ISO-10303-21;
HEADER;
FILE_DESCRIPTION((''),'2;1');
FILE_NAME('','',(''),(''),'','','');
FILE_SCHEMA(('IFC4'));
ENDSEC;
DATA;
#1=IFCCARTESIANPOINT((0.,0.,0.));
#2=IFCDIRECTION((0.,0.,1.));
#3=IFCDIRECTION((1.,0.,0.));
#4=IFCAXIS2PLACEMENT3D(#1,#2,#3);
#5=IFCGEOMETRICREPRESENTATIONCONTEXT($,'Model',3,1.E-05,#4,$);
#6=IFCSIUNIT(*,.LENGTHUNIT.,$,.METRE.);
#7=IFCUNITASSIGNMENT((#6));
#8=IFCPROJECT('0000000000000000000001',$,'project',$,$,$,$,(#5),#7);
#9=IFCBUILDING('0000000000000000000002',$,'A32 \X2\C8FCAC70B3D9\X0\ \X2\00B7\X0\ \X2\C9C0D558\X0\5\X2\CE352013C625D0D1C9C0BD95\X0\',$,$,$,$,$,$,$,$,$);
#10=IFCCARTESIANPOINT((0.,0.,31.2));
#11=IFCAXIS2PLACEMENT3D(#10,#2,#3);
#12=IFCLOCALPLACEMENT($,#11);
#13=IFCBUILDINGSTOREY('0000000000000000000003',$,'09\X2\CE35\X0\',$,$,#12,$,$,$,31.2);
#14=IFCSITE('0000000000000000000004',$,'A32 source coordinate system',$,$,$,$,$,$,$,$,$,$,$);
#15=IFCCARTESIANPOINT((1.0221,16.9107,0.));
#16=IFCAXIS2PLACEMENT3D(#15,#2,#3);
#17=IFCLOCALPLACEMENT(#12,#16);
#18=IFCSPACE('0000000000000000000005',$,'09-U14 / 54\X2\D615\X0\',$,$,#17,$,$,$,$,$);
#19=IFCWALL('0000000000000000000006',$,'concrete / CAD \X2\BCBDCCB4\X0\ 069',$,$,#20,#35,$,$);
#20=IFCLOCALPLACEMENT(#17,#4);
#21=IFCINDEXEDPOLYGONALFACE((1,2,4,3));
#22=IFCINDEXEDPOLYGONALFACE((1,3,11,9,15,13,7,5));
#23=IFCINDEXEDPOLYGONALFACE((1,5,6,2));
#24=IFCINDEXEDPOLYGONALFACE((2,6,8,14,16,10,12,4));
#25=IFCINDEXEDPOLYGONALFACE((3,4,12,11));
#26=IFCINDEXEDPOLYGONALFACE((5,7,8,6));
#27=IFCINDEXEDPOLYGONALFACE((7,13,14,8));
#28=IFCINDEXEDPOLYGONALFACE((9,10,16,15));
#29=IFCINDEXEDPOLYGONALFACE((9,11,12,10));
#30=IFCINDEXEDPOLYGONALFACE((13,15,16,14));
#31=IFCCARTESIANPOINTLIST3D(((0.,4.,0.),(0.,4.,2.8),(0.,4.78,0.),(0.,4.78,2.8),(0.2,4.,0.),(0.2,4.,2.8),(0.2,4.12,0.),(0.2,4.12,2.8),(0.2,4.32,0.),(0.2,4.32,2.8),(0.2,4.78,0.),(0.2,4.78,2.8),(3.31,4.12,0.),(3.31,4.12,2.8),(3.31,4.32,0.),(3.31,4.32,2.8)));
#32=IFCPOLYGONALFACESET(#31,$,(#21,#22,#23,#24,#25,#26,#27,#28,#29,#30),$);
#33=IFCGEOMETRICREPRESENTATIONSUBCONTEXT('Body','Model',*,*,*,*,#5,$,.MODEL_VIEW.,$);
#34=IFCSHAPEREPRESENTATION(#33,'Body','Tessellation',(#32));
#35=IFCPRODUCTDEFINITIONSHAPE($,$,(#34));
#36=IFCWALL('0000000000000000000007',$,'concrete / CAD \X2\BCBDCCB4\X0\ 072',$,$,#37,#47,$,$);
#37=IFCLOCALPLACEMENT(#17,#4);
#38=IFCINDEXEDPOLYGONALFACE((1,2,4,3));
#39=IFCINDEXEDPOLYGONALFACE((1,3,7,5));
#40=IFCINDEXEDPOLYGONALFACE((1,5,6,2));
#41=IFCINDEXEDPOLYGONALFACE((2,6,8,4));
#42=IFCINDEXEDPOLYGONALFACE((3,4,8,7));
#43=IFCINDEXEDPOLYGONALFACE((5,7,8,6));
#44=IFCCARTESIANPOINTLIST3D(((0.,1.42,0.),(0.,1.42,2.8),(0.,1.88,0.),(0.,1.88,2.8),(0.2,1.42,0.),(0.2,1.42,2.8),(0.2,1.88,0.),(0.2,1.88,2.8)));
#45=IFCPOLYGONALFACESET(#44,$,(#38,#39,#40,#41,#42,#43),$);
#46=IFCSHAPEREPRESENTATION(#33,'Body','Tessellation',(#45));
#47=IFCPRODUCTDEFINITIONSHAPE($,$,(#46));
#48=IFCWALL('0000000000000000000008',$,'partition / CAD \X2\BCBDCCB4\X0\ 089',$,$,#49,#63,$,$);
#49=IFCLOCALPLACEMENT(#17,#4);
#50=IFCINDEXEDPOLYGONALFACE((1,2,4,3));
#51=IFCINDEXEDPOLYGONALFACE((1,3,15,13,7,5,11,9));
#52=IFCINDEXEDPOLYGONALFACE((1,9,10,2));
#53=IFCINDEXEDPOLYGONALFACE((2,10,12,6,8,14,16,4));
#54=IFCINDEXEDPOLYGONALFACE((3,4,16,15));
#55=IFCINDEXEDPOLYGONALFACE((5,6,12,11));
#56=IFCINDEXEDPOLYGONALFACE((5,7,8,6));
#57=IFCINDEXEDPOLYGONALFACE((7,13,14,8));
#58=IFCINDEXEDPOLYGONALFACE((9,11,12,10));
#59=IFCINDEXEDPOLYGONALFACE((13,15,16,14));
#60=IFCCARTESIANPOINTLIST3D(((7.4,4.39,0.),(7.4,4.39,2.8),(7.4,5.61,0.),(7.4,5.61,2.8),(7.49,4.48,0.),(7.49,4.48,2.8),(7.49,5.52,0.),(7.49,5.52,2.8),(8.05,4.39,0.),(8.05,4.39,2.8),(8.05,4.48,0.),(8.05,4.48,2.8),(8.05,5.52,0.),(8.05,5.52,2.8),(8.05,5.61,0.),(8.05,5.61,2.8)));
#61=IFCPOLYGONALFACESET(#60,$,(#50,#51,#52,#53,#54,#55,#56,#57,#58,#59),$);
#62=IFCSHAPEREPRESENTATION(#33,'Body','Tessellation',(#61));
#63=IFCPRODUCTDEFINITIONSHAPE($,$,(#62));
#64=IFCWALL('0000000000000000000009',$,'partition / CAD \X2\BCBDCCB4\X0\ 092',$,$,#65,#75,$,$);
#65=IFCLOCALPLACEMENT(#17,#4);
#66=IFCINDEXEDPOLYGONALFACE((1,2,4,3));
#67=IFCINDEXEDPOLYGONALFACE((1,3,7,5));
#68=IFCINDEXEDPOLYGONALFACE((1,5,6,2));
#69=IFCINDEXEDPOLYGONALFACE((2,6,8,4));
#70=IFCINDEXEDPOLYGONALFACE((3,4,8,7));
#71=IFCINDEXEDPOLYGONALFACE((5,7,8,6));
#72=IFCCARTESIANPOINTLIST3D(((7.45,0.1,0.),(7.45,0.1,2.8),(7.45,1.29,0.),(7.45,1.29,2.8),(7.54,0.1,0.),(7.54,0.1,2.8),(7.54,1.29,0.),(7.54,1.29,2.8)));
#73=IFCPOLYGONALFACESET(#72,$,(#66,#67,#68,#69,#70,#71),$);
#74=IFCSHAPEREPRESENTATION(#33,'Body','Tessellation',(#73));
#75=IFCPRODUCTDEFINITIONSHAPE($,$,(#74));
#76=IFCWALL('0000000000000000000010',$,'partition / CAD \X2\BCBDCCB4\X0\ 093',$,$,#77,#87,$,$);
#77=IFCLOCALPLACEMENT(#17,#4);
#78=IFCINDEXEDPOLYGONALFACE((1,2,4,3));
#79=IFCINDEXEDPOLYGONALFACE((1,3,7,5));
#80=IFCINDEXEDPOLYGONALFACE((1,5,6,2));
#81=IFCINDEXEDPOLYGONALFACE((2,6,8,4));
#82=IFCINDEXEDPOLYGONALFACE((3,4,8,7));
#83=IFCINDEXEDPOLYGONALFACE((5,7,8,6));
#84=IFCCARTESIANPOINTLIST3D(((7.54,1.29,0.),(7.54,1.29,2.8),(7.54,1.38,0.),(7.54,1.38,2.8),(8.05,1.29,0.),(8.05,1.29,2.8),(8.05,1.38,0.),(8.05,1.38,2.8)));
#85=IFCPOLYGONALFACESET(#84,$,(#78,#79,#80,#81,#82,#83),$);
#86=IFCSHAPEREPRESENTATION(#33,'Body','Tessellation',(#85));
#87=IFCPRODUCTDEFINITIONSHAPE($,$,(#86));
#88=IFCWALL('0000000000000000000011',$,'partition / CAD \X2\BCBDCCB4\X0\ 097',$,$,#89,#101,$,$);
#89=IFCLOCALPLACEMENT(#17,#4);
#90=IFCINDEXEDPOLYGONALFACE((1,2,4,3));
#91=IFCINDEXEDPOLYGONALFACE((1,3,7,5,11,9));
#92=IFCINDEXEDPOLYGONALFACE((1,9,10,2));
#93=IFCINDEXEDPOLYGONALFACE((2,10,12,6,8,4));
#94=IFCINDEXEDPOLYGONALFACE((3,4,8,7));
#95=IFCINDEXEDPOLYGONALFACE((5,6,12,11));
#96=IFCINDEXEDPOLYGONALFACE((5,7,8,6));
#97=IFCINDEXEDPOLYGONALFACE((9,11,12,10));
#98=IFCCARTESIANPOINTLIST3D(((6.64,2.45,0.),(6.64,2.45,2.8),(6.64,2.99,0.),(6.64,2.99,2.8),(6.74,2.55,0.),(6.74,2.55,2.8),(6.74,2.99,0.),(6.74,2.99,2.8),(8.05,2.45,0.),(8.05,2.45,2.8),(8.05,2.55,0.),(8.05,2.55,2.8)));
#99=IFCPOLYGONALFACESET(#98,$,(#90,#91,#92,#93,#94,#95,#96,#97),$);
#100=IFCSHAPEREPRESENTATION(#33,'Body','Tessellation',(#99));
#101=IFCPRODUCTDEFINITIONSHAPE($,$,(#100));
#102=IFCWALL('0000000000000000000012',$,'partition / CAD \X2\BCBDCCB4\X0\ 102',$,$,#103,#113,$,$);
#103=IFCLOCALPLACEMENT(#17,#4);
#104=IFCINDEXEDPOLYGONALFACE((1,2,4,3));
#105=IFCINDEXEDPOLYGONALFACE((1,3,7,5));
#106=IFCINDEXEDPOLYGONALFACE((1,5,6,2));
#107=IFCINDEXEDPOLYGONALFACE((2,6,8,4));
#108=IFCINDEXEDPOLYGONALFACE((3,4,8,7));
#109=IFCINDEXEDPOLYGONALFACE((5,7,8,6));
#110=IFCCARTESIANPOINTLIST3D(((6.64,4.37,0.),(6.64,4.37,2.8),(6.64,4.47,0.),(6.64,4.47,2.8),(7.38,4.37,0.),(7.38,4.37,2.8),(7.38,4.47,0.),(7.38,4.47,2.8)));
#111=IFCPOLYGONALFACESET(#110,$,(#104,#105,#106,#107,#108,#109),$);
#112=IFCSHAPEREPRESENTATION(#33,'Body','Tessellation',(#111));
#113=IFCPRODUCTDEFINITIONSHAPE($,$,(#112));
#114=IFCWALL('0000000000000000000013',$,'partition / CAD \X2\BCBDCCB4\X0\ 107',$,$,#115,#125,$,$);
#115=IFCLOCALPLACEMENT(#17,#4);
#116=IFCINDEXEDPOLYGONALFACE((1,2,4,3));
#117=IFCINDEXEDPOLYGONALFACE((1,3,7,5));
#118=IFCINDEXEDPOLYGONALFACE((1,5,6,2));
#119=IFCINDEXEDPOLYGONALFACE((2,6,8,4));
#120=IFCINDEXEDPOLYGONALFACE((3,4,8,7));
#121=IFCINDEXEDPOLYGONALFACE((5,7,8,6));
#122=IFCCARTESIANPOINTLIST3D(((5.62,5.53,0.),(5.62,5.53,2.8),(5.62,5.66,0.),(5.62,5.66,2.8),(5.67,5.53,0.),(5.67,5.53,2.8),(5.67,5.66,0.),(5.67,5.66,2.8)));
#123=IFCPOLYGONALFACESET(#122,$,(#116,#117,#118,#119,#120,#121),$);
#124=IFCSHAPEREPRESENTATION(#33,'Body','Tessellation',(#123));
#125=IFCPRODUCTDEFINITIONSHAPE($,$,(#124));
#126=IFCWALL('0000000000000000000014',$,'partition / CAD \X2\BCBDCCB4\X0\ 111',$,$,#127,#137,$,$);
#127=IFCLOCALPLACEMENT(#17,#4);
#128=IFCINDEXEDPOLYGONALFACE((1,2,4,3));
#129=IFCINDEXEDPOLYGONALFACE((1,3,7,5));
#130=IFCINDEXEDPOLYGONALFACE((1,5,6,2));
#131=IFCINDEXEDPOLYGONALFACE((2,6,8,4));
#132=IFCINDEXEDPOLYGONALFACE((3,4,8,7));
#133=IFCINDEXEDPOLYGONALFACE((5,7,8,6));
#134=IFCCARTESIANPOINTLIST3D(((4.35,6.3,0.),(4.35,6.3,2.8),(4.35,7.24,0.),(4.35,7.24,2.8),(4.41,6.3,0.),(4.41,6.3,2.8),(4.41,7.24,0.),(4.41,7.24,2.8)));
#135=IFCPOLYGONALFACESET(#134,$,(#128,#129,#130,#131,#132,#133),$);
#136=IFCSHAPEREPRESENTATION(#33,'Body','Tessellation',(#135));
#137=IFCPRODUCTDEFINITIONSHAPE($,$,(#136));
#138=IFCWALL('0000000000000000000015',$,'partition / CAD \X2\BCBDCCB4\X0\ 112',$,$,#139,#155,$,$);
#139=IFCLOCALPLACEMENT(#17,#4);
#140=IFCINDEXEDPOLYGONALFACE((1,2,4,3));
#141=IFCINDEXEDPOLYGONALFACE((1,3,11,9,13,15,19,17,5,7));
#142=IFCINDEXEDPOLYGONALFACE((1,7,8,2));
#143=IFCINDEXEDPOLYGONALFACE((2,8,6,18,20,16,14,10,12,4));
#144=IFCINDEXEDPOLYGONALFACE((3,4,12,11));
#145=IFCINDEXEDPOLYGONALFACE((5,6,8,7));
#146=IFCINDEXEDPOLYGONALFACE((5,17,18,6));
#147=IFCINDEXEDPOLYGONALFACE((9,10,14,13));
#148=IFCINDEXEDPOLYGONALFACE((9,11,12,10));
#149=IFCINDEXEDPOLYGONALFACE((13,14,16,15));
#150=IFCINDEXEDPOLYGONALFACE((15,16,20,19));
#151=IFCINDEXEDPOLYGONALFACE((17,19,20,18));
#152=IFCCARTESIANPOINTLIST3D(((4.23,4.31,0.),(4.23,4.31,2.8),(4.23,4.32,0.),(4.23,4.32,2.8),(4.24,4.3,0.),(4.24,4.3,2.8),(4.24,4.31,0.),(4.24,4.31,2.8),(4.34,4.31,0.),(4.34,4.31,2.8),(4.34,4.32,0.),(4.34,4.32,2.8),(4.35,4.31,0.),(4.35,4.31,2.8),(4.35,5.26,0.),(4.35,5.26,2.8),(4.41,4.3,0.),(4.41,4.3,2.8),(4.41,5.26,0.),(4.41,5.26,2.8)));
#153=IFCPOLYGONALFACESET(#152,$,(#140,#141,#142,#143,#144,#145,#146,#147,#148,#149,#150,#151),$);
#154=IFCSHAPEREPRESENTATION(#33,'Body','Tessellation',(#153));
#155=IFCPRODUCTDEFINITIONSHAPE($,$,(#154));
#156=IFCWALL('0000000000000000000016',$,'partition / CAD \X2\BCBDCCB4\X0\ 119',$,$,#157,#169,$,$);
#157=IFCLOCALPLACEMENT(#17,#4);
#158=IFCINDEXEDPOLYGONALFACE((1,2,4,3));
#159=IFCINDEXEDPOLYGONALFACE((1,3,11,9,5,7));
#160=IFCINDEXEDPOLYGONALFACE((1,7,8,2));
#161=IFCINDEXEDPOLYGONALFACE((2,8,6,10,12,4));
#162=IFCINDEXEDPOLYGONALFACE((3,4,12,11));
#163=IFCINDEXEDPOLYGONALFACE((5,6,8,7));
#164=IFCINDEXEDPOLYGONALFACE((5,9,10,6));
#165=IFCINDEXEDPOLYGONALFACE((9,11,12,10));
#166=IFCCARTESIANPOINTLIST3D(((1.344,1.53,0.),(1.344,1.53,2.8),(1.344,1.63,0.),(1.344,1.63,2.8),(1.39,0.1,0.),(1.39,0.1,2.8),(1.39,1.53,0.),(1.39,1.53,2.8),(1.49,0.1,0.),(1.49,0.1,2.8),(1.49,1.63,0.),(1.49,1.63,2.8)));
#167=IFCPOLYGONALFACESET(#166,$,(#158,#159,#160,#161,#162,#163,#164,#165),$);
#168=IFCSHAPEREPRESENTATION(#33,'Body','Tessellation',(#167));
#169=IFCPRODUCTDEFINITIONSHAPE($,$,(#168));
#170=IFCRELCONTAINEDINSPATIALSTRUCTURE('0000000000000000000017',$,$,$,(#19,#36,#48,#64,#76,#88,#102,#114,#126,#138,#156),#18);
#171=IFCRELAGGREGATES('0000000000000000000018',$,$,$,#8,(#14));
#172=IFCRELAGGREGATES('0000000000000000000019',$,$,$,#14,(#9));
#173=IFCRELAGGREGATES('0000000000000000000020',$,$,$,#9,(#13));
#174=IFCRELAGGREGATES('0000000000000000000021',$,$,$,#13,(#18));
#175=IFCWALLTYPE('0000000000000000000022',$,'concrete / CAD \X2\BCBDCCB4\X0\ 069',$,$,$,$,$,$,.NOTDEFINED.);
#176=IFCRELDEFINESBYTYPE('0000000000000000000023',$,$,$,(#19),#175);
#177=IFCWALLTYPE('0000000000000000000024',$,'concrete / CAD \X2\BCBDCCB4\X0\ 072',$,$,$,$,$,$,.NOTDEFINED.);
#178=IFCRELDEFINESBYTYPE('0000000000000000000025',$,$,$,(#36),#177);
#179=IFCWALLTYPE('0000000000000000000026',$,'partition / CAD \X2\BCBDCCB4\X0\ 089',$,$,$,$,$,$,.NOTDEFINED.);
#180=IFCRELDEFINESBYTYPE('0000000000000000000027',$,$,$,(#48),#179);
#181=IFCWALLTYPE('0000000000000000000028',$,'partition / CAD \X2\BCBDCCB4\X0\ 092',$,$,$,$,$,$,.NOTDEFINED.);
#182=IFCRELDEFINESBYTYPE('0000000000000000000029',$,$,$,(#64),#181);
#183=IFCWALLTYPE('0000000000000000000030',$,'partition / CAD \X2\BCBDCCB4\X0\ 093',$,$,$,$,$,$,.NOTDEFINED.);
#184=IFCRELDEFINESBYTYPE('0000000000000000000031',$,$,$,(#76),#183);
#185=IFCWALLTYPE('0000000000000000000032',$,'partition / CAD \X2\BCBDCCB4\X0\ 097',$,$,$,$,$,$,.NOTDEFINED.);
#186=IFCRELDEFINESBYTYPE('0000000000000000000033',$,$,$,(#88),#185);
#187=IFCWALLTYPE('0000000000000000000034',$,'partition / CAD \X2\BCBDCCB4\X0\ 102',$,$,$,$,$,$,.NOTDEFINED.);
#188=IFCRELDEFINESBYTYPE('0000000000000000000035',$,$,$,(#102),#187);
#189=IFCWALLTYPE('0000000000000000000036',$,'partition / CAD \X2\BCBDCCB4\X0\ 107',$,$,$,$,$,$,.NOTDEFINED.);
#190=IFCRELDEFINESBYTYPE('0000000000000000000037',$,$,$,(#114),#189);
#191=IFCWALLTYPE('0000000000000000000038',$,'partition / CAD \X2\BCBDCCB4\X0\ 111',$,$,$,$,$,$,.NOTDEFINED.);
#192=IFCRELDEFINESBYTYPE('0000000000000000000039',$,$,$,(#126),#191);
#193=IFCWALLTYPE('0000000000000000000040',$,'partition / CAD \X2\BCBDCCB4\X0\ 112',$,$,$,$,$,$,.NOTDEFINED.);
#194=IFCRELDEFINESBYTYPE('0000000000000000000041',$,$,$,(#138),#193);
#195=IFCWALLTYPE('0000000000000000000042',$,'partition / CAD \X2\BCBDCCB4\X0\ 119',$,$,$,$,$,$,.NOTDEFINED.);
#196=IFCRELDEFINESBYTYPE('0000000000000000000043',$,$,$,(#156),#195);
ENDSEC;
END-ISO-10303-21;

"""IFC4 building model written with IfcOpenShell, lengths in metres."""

from ifc_helpers import new_model, si_unit, frame, origin, origin_with_axes, place, context, subcontext, project, spatial, polyline, outline, extrude, source, transform, mapped, type_object, type_shapes, element, save


model = new_model("IFC4")

# Units and contexts
model_context = context("Model", 3, precision=1e-05, world=origin_with_axes())
body_context = subcontext(model_context, "Body", "Model", "MODEL_VIEW")
ifc_project = project(units=[si_unit("LENGTHUNIT", "METRE")], contexts=[model_context])

# Site, building, storey, space
site = spatial("IfcSite", under=ifc_project, Name="A32 source coordinate system")
building = spatial("IfcBuilding", under=site, Name="A32 주거동 · 지하5층–옥탑지붕")
storey_placement = place(None, frame((0.0, 0.0, 31.2), z_axis=(0.0, 0.0, 1.0), x_axis=(1.0, 0.0, 0.0)))
storey = spatial("IfcBuildingStorey", under=building, at=storey_placement, Name="09층", Elevation=31.2)
space_placement = place(storey_placement, frame((1.0221, 16.9107, 0.0), z_axis=(0.0, 0.0, 1.0), x_axis=(1.0, 0.0, 0.0)))
space = spatial("IfcSpace", under=storey, at=space_placement, Name="09-U14 / 54형")

# Walls
wall_type_1 = type_object("IfcWallType", Name="concrete / CAD 벽체 069", PredefinedType="NOTDEFINED")
shared_shape_1 = source(origin(), body_context, "Body", "SweptSolid", [
    extrude(outline(polyline([(0.2, 4.12), (0.2, 4.0), (0.0, 4.0), (0.0, 4.78), (0.2, 4.78), (0.2, 4.32), (3.31, 4.32), (3.31, 4.12), (0.2, 4.12)])), origin(), (0.0, 0.0, 1.0), 2.8),
])
type_shapes(wall_type_1, [shared_shape_1])
wall_1_placement = place(space_placement, origin_with_axes())
element("IfcWall", 1, at=wall_1_placement, inside=space, type_object=wall_type_1, Name="concrete / CAD 벽체 069", context=body_context, shape_type="MappedRepresentation", body=[
    mapped(shared_shape_1, transform((0.0, 0.0, 0.0), scale=1.0)),
])
wall_type_2 = type_object("IfcWallType", Name="concrete / CAD 벽체 072", PredefinedType="NOTDEFINED")
shared_shape_2 = source(origin(), body_context, "Body", "SweptSolid", [
    extrude(outline(polyline([(0.2, 1.88), (0.2, 1.42), (0.0, 1.42), (0.0, 1.88), (0.2, 1.88)])), origin(), (0.0, 0.0, 1.0), 2.8),
])
type_shapes(wall_type_2, [shared_shape_2])
wall_2_placement = place(space_placement, origin_with_axes())
element("IfcWall", 2, at=wall_2_placement, inside=space, type_object=wall_type_2, Name="concrete / CAD 벽체 072", context=body_context, shape_type="MappedRepresentation", body=[
    mapped(shared_shape_2, transform((0.0, 0.0, 0.0), scale=1.0)),
])
wall_type_3 = type_object("IfcWallType", Name="partition / CAD 벽체 089", PredefinedType="NOTDEFINED")
shared_shape_3 = source(origin(), body_context, "Body", "SweptSolid", [
    extrude(outline(polyline([(7.49, 4.48), (8.05, 4.48), (8.05, 4.39), (7.4, 4.39), (7.4, 5.61), (8.05, 5.61), (8.05, 5.52), (7.49, 5.52), (7.49, 4.48)])), origin(), (0.0, 0.0, 1.0), 2.8),
])
type_shapes(wall_type_3, [shared_shape_3])
wall_3_placement = place(space_placement, origin_with_axes())
element("IfcWall", 3, at=wall_3_placement, inside=space, type_object=wall_type_3, Name="partition / CAD 벽체 089", context=body_context, shape_type="MappedRepresentation", body=[
    mapped(shared_shape_3, transform((0.0, 0.0, 0.0), scale=1.0)),
])
wall_type_4 = type_object("IfcWallType", Name="partition / CAD 벽체 092", PredefinedType="NOTDEFINED")
shared_shape_4 = source(origin(), body_context, "Body", "SweptSolid", [
    extrude(outline(polyline([(7.54, 1.29), (7.54, 0.1), (7.45, 0.1), (7.45, 1.29), (7.54, 1.29)])), origin(), (0.0, 0.0, 1.0), 2.8),
])
type_shapes(wall_type_4, [shared_shape_4])
wall_4_placement = place(space_placement, origin_with_axes())
element("IfcWall", 4, at=wall_4_placement, inside=space, type_object=wall_type_4, Name="partition / CAD 벽체 092", context=body_context, shape_type="MappedRepresentation", body=[
    mapped(shared_shape_4, transform((0.0, 0.0, 0.0), scale=1.0)),
])
wall_type_5 = type_object("IfcWallType", Name="partition / CAD 벽체 093", PredefinedType="NOTDEFINED")
shared_shape_5 = source(origin(), body_context, "Body", "SweptSolid", [
    extrude(outline(polyline([(8.05, 1.29), (7.54, 1.29), (7.54, 1.38), (8.05, 1.38), (8.05, 1.29)])), origin(), (0.0, 0.0, 1.0), 2.8),
])
type_shapes(wall_type_5, [shared_shape_5])
wall_5_placement = place(space_placement, origin_with_axes())
element("IfcWall", 5, at=wall_5_placement, inside=space, type_object=wall_type_5, Name="partition / CAD 벽체 093", context=body_context, shape_type="MappedRepresentation", body=[
    mapped(shared_shape_5, transform((0.0, 0.0, 0.0), scale=1.0)),
])
wall_type_6 = type_object("IfcWallType", Name="partition / CAD 벽체 097", PredefinedType="NOTDEFINED")
shared_shape_6 = source(origin(), body_context, "Body", "SweptSolid", [
    extrude(outline(polyline([(8.05, 2.45), (6.64, 2.45), (6.64, 2.99), (6.74, 2.99), (6.74, 2.55), (8.05, 2.55), (8.05, 2.45)])), origin(), (0.0, 0.0, 1.0), 2.8),
])
type_shapes(wall_type_6, [shared_shape_6])
wall_6_placement = place(space_placement, origin_with_axes())
element("IfcWall", 6, at=wall_6_placement, inside=space, type_object=wall_type_6, Name="partition / CAD 벽체 097", context=body_context, shape_type="MappedRepresentation", body=[
    mapped(shared_shape_6, transform((0.0, 0.0, 0.0), scale=1.0)),
])
wall_type_7 = type_object("IfcWallType", Name="partition / CAD 벽체 102", PredefinedType="NOTDEFINED")
shared_shape_7 = source(origin(), body_context, "Body", "SweptSolid", [
    extrude(outline(polyline([(7.38, 4.47), (7.38, 4.37), (6.64, 4.37), (6.64, 4.47), (7.38, 4.47)])), origin(), (0.0, 0.0, 1.0), 2.8),
])
type_shapes(wall_type_7, [shared_shape_7])
wall_7_placement = place(space_placement, origin_with_axes())
element("IfcWall", 7, at=wall_7_placement, inside=space, type_object=wall_type_7, Name="partition / CAD 벽체 102", context=body_context, shape_type="MappedRepresentation", body=[
    mapped(shared_shape_7, transform((0.0, 0.0, 0.0), scale=1.0)),
])
wall_type_8 = type_object("IfcWallType", Name="partition / CAD 벽체 107", PredefinedType="NOTDEFINED")
shared_shape_8 = source(origin(), body_context, "Body", "SweptSolid", [
    extrude(outline(polyline([(5.62, 5.53), (5.62, 5.66), (5.67, 5.66), (5.67, 5.53), (5.62, 5.53)])), origin(), (0.0, 0.0, 1.0), 2.8),
])
type_shapes(wall_type_8, [shared_shape_8])
wall_8_placement = place(space_placement, origin_with_axes())
element("IfcWall", 8, at=wall_8_placement, inside=space, type_object=wall_type_8, Name="partition / CAD 벽체 107", context=body_context, shape_type="MappedRepresentation", body=[
    mapped(shared_shape_8, transform((0.0, 0.0, 0.0), scale=1.0)),
])
wall_type_9 = type_object("IfcWallType", Name="partition / CAD 벽체 111", PredefinedType="NOTDEFINED")
shared_shape_9 = source(origin(), body_context, "Body", "SweptSolid", [
    extrude(outline(polyline([(4.41, 7.24), (4.41, 6.3), (4.35, 6.3), (4.35, 7.24), (4.41, 7.24)])), origin(), (0.0, 0.0, 1.0), 2.8),
])
type_shapes(wall_type_9, [shared_shape_9])
wall_9_placement = place(space_placement, origin_with_axes())
element("IfcWall", 9, at=wall_9_placement, inside=space, type_object=wall_type_9, Name="partition / CAD 벽체 111", context=body_context, shape_type="MappedRepresentation", body=[
    mapped(shared_shape_9, transform((0.0, 0.0, 0.0), scale=1.0)),
])
wall_type_10 = type_object("IfcWallType", Name="partition / CAD 벽체 112", PredefinedType="NOTDEFINED")
shared_shape_10 = source(origin(), body_context, "Body", "SweptSolid", [
    extrude(outline(polyline([(4.24, 4.3), (4.24, 4.31), (4.23, 4.31), (4.23, 4.32), (4.34, 4.32), (4.34, 4.31), (4.35, 4.31), (4.35, 5.26), (4.41, 5.26), (4.41, 4.3), (4.24, 4.3)])), origin(), (0.0, 0.0, 1.0), 2.8),
])
type_shapes(wall_type_10, [shared_shape_10])
wall_10_placement = place(space_placement, origin_with_axes())
element("IfcWall", 10, at=wall_10_placement, inside=space, type_object=wall_type_10, Name="partition / CAD 벽체 112", context=body_context, shape_type="MappedRepresentation", body=[
    mapped(shared_shape_10, transform((0.0, 0.0, 0.0), scale=1.0)),
])
wall_type_11 = type_object("IfcWallType", Name="partition / CAD 벽체 119", PredefinedType="NOTDEFINED")
shared_shape_11 = source(origin(), body_context, "Body", "SweptSolid", [
    extrude(outline(polyline([(1.344, 1.53), (1.344, 1.63), (1.49, 1.63), (1.49, 0.1), (1.39, 0.1), (1.39, 1.53), (1.344, 1.53)])), origin(), (0.0, 0.0, 1.0), 2.8),
])
type_shapes(wall_type_11, [shared_shape_11])
wall_11_placement = place(space_placement, origin_with_axes())
element("IfcWall", 11, at=wall_11_placement, inside=space, type_object=wall_type_11, Name="partition / CAD 벽체 119", context=body_context, shape_type="MappedRepresentation", body=[
    mapped(shared_shape_11, transform((0.0, 0.0, 0.0), scale=1.0)),
])

save(model, "model.ifc")
